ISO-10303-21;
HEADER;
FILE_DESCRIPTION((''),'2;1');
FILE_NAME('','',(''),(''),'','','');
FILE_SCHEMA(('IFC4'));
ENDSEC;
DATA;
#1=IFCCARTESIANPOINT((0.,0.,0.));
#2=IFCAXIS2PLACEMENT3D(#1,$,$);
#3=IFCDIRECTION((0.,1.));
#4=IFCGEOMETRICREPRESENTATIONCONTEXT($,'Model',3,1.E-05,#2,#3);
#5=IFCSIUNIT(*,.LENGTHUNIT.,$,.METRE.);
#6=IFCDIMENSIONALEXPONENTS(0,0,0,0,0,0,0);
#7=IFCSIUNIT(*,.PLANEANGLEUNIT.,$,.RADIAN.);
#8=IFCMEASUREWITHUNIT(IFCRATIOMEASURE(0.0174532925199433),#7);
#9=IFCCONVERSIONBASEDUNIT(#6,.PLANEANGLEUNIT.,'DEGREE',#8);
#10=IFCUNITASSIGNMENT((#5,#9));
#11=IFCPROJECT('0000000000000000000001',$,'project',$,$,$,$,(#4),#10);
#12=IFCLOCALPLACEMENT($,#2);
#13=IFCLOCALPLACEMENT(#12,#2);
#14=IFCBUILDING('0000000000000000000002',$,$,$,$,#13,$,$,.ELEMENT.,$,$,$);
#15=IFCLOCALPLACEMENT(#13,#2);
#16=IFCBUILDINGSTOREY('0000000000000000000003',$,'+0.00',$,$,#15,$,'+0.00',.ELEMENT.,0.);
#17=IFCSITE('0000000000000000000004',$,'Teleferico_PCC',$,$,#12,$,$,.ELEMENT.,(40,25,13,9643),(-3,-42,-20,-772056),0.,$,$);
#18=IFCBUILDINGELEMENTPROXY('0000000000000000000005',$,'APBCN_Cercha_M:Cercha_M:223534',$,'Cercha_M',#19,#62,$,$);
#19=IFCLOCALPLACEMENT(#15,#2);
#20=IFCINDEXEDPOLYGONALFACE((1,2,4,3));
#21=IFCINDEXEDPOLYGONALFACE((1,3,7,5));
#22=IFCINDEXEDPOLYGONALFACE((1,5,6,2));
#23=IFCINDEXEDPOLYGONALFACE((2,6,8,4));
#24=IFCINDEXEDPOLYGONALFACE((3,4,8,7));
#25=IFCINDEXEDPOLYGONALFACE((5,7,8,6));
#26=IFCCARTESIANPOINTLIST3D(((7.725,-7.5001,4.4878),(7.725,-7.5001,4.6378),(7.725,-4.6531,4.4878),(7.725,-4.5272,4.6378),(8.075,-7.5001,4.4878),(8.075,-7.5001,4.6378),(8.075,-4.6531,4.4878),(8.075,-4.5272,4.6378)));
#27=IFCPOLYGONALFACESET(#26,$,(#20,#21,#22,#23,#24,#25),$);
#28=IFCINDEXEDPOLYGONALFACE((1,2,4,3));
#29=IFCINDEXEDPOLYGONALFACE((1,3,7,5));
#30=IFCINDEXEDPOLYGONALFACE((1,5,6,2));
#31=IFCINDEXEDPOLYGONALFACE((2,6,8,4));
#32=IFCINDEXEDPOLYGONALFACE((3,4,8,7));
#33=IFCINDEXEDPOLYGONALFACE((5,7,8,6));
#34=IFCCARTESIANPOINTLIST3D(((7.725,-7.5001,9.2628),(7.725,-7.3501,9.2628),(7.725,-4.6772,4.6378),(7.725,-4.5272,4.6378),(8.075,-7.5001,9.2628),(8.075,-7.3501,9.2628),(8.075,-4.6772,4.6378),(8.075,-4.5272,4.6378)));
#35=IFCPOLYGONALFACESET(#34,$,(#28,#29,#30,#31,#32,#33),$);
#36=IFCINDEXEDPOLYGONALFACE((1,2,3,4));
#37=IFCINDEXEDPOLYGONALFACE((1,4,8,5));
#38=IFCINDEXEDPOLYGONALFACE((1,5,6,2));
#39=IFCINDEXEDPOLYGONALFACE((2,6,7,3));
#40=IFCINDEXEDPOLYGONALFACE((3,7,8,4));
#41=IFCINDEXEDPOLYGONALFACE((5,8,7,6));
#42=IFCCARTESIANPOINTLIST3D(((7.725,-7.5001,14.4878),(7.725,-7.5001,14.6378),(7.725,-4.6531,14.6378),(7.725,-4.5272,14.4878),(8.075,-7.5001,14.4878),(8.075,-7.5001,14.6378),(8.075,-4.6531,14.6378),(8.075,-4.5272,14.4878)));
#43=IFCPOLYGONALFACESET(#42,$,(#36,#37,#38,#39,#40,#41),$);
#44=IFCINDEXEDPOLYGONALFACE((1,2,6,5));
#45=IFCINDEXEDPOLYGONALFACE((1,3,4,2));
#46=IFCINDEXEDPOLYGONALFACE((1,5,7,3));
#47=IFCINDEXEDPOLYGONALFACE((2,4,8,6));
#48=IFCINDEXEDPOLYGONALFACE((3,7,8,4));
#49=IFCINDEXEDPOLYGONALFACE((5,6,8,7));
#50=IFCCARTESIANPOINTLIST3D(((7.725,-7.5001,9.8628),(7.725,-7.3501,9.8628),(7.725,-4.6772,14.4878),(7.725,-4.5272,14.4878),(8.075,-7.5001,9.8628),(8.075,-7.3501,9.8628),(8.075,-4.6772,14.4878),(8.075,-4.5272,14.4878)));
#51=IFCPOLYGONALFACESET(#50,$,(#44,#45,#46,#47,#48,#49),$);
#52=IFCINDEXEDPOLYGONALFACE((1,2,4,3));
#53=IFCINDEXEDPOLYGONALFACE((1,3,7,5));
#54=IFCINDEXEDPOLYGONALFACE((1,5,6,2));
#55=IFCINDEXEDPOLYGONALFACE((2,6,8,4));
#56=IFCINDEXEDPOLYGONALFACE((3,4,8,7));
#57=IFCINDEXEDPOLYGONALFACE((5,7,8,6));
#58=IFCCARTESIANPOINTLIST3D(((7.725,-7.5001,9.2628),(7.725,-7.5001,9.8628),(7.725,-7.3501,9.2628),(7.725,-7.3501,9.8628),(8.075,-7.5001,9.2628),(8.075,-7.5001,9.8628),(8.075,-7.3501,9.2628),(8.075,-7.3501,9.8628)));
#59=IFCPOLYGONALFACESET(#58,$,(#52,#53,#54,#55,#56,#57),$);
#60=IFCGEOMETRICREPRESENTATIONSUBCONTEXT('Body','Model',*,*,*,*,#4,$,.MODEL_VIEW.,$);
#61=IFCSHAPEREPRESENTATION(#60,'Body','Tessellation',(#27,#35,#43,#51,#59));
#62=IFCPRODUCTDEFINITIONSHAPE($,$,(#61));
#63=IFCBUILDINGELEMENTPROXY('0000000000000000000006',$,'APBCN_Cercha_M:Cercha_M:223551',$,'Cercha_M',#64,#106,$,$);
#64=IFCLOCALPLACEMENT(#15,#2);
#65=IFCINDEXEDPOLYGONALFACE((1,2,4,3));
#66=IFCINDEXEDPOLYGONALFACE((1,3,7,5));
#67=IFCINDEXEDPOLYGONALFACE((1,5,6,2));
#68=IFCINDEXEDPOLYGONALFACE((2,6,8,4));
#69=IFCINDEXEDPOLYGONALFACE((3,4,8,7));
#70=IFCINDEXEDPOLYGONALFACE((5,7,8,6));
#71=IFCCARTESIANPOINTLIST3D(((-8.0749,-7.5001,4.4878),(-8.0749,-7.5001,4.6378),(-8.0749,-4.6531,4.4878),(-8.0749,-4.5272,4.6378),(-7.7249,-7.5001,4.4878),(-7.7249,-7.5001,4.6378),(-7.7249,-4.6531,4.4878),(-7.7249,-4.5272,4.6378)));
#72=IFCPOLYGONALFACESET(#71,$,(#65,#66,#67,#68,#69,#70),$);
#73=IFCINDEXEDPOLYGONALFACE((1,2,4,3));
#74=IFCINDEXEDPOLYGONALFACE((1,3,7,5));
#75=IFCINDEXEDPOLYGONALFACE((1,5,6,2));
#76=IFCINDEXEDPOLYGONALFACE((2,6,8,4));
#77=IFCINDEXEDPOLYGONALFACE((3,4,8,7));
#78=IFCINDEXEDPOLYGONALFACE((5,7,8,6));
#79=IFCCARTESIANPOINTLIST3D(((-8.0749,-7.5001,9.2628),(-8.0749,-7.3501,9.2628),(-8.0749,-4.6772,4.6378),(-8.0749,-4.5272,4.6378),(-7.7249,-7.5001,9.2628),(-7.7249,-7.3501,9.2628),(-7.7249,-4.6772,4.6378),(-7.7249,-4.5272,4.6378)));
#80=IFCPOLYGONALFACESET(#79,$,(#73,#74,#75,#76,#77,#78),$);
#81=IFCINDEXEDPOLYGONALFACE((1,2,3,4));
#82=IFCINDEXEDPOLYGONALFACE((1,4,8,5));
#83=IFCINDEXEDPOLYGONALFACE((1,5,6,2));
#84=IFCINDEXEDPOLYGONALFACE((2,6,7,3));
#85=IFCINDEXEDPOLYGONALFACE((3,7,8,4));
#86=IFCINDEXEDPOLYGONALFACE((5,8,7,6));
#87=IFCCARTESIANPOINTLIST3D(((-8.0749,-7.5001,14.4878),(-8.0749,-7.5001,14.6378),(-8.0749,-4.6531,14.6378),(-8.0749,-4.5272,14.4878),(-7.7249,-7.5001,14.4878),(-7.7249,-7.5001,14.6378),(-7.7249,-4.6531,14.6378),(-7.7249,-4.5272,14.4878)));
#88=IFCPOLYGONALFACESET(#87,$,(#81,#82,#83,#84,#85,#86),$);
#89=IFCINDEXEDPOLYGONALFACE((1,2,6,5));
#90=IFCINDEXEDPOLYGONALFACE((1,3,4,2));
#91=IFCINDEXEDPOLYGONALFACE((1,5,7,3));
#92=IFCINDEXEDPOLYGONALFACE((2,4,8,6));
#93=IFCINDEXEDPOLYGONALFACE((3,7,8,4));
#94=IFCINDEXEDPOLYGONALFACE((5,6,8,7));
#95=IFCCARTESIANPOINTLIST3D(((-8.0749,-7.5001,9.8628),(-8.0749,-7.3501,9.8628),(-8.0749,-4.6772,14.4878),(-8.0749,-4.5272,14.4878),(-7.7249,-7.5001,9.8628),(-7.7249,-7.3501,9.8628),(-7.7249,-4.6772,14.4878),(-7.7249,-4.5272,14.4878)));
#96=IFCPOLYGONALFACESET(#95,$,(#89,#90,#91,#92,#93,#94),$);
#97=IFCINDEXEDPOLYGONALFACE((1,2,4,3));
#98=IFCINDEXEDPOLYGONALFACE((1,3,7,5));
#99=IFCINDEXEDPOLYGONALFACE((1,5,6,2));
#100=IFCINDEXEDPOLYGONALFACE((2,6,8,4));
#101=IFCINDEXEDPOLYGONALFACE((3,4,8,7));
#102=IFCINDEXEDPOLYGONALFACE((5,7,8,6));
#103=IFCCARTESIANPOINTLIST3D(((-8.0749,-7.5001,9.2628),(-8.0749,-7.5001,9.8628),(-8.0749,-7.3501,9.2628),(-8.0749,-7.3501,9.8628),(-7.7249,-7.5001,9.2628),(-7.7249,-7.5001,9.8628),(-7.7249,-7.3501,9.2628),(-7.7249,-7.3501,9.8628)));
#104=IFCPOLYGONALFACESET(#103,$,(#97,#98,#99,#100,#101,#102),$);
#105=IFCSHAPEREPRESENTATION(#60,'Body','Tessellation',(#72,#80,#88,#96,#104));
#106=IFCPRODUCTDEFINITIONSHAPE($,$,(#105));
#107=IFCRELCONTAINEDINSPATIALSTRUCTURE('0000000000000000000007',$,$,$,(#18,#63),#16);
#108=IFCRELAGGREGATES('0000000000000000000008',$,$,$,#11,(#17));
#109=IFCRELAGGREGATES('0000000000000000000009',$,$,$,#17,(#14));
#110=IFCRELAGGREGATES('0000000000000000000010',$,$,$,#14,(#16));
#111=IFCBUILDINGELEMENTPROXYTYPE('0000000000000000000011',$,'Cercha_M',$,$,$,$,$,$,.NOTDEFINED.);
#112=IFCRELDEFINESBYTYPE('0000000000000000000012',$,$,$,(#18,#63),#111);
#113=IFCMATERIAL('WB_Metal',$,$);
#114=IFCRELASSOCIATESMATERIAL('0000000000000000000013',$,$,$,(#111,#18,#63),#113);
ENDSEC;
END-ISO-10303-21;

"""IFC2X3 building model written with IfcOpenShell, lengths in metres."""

from ifc_helpers import new_model, entity, si_unit, converted_unit, direction, frame, origin, origin_2d_with_axis, place, context, subcontext, project, spatial, polyline, rectangle, outline, extrude, source, transform, mapped, material, type_object, type_shapes, element, save


model = new_model("IFC2X3")

# Units and contexts
model_context = context("Model", 3, precision=1e-05, world=origin(), true_north=direction((0.0, 1.0)))
body_context = subcontext(model_context, "Body", "Model", "MODEL_VIEW")
ifc_project = project(units=[si_unit("LENGTHUNIT", "METRE"), converted_unit("PLANEANGLEUNIT", "DEGREE", entity("IfcRatioMeasure", 0.0174532925199433), si_unit("PLANEANGLEUNIT", "RADIAN"), dimensions=[0, 0, 0, 0, 0, 0, 0])], contexts=[model_context])

# Site, building, storey
site_placement = place(None, origin())
site = spatial("IfcSite", under=ifc_project, at=site_placement, Name="Teleferico_PCC", CompositionType="ELEMENT", RefLatitude=(40, 25, 13, 9643), RefLongitude=(-3, -42, -20, -772056), RefElevation=0.0)
building_placement = place(site_placement, origin())
building = spatial("IfcBuilding", under=site, at=building_placement, CompositionType="ELEMENT")
storey_placement = place(building_placement, origin())
storey = spatial("IfcBuildingStorey", under=building, at=storey_placement, Name="+0.00", LongName="+0.00", CompositionType="ELEMENT", Elevation=0.0)

# Shared definitions
ifc_material = material(Name="WB_Metal")

# Building element proxies
building_element_proxy_type_1 = type_object("IfcBuildingElementProxyType", Name="Cercha_M", PredefinedType="NOTDEFINED", material=ifc_material)
shared_shape_1 = source(origin(), body_context, "Body", "SweptSolid", [
    extrude(outline(polyline([(-0.075, -1.455), (0.075, -1.455), (0.075, 1.3921), (-0.075, 1.5179), (-0.075, -1.455)])), frame((-1.455, -0.175, -5.0), z_axis=(0.0, 1.0, 0.0), x_axis=(0.0, 0.0, -1.0)), (0.0, 0.0, 1.0), 0.35),
    extrude(outline(polyline([(1.3365, -2.3125), (1.4865, -2.3125), (-1.3365, 2.3125), (-1.4865, 2.3125), (1.3365, -2.3125)])), frame((-1.4865, -0.175, -2.6125), z_axis=(0.0, 1.0, 0.0), x_axis=(1.0, 0.0, 0.0)), (0.0, 0.0, 1.0), 0.35),
    extrude(outline(polyline([(-0.075, -1.455), (0.075, -1.455), (0.075, 1.5179), (-0.075, 1.3921), (-0.075, -1.455)])), frame((-1.455, -0.175, 5.0), z_axis=(0.0, 1.0, 0.0), x_axis=(0.0, 0.0, -1.0)), (0.0, 0.0, 1.0), 0.35),
    extrude(outline(polyline([(-2.6701, -0.064), (2.7483, -0.064), (2.6701, 0.064), (-2.7483, 0.064), (-2.6701, -0.064)])), frame((-1.4865, -0.175, 2.6125), z_axis=(0.0, 1.0, 0.0), x_axis=(-0.520985, 0.0, 0.853566)), (0.0, 0.0, 1.0), 0.35),
    extrude(rectangle(XDim=0.15, YDim=0.35, at=origin_2d_with_axis()), frame((-0.075, 0.0, -0.3), z_axis=(0.0, 0.0, 1.0), x_axis=(-1.0, 0.0, 0.0)), (0.0, 0.0, 1.0), 0.6),
])
type_shapes(building_element_proxy_type_1, [shared_shape_1])
for number, where, z_axis, x_axis, name in (
    (1, (7.9, -7.5001, 9.5628), (0.0, 0.0, 1.0), (0.0, -1.0, 0.0), "APBCN_Cercha_M:Cercha_M:223534"),
    (2, (-7.8999, -7.5001, 9.5628), (0.0, 0.0, 1.0), (0.0, -1.0, 0.0), "APBCN_Cercha_M:Cercha_M:223551"),
):
    element("IfcBuildingElementProxy", number, at=place(storey_placement, frame(where, z_axis=z_axis, x_axis=x_axis)), inside=storey, type_object=building_element_proxy_type_1, material=ifc_material, Name=name, ObjectType="Cercha_M", context=body_context, shape_type="MappedRepresentation", body=[
        mapped(shared_shape_1, transform((0.0, 0.0, 0.0), scale=1.0)),
    ])

save(model, "model.ifc")
